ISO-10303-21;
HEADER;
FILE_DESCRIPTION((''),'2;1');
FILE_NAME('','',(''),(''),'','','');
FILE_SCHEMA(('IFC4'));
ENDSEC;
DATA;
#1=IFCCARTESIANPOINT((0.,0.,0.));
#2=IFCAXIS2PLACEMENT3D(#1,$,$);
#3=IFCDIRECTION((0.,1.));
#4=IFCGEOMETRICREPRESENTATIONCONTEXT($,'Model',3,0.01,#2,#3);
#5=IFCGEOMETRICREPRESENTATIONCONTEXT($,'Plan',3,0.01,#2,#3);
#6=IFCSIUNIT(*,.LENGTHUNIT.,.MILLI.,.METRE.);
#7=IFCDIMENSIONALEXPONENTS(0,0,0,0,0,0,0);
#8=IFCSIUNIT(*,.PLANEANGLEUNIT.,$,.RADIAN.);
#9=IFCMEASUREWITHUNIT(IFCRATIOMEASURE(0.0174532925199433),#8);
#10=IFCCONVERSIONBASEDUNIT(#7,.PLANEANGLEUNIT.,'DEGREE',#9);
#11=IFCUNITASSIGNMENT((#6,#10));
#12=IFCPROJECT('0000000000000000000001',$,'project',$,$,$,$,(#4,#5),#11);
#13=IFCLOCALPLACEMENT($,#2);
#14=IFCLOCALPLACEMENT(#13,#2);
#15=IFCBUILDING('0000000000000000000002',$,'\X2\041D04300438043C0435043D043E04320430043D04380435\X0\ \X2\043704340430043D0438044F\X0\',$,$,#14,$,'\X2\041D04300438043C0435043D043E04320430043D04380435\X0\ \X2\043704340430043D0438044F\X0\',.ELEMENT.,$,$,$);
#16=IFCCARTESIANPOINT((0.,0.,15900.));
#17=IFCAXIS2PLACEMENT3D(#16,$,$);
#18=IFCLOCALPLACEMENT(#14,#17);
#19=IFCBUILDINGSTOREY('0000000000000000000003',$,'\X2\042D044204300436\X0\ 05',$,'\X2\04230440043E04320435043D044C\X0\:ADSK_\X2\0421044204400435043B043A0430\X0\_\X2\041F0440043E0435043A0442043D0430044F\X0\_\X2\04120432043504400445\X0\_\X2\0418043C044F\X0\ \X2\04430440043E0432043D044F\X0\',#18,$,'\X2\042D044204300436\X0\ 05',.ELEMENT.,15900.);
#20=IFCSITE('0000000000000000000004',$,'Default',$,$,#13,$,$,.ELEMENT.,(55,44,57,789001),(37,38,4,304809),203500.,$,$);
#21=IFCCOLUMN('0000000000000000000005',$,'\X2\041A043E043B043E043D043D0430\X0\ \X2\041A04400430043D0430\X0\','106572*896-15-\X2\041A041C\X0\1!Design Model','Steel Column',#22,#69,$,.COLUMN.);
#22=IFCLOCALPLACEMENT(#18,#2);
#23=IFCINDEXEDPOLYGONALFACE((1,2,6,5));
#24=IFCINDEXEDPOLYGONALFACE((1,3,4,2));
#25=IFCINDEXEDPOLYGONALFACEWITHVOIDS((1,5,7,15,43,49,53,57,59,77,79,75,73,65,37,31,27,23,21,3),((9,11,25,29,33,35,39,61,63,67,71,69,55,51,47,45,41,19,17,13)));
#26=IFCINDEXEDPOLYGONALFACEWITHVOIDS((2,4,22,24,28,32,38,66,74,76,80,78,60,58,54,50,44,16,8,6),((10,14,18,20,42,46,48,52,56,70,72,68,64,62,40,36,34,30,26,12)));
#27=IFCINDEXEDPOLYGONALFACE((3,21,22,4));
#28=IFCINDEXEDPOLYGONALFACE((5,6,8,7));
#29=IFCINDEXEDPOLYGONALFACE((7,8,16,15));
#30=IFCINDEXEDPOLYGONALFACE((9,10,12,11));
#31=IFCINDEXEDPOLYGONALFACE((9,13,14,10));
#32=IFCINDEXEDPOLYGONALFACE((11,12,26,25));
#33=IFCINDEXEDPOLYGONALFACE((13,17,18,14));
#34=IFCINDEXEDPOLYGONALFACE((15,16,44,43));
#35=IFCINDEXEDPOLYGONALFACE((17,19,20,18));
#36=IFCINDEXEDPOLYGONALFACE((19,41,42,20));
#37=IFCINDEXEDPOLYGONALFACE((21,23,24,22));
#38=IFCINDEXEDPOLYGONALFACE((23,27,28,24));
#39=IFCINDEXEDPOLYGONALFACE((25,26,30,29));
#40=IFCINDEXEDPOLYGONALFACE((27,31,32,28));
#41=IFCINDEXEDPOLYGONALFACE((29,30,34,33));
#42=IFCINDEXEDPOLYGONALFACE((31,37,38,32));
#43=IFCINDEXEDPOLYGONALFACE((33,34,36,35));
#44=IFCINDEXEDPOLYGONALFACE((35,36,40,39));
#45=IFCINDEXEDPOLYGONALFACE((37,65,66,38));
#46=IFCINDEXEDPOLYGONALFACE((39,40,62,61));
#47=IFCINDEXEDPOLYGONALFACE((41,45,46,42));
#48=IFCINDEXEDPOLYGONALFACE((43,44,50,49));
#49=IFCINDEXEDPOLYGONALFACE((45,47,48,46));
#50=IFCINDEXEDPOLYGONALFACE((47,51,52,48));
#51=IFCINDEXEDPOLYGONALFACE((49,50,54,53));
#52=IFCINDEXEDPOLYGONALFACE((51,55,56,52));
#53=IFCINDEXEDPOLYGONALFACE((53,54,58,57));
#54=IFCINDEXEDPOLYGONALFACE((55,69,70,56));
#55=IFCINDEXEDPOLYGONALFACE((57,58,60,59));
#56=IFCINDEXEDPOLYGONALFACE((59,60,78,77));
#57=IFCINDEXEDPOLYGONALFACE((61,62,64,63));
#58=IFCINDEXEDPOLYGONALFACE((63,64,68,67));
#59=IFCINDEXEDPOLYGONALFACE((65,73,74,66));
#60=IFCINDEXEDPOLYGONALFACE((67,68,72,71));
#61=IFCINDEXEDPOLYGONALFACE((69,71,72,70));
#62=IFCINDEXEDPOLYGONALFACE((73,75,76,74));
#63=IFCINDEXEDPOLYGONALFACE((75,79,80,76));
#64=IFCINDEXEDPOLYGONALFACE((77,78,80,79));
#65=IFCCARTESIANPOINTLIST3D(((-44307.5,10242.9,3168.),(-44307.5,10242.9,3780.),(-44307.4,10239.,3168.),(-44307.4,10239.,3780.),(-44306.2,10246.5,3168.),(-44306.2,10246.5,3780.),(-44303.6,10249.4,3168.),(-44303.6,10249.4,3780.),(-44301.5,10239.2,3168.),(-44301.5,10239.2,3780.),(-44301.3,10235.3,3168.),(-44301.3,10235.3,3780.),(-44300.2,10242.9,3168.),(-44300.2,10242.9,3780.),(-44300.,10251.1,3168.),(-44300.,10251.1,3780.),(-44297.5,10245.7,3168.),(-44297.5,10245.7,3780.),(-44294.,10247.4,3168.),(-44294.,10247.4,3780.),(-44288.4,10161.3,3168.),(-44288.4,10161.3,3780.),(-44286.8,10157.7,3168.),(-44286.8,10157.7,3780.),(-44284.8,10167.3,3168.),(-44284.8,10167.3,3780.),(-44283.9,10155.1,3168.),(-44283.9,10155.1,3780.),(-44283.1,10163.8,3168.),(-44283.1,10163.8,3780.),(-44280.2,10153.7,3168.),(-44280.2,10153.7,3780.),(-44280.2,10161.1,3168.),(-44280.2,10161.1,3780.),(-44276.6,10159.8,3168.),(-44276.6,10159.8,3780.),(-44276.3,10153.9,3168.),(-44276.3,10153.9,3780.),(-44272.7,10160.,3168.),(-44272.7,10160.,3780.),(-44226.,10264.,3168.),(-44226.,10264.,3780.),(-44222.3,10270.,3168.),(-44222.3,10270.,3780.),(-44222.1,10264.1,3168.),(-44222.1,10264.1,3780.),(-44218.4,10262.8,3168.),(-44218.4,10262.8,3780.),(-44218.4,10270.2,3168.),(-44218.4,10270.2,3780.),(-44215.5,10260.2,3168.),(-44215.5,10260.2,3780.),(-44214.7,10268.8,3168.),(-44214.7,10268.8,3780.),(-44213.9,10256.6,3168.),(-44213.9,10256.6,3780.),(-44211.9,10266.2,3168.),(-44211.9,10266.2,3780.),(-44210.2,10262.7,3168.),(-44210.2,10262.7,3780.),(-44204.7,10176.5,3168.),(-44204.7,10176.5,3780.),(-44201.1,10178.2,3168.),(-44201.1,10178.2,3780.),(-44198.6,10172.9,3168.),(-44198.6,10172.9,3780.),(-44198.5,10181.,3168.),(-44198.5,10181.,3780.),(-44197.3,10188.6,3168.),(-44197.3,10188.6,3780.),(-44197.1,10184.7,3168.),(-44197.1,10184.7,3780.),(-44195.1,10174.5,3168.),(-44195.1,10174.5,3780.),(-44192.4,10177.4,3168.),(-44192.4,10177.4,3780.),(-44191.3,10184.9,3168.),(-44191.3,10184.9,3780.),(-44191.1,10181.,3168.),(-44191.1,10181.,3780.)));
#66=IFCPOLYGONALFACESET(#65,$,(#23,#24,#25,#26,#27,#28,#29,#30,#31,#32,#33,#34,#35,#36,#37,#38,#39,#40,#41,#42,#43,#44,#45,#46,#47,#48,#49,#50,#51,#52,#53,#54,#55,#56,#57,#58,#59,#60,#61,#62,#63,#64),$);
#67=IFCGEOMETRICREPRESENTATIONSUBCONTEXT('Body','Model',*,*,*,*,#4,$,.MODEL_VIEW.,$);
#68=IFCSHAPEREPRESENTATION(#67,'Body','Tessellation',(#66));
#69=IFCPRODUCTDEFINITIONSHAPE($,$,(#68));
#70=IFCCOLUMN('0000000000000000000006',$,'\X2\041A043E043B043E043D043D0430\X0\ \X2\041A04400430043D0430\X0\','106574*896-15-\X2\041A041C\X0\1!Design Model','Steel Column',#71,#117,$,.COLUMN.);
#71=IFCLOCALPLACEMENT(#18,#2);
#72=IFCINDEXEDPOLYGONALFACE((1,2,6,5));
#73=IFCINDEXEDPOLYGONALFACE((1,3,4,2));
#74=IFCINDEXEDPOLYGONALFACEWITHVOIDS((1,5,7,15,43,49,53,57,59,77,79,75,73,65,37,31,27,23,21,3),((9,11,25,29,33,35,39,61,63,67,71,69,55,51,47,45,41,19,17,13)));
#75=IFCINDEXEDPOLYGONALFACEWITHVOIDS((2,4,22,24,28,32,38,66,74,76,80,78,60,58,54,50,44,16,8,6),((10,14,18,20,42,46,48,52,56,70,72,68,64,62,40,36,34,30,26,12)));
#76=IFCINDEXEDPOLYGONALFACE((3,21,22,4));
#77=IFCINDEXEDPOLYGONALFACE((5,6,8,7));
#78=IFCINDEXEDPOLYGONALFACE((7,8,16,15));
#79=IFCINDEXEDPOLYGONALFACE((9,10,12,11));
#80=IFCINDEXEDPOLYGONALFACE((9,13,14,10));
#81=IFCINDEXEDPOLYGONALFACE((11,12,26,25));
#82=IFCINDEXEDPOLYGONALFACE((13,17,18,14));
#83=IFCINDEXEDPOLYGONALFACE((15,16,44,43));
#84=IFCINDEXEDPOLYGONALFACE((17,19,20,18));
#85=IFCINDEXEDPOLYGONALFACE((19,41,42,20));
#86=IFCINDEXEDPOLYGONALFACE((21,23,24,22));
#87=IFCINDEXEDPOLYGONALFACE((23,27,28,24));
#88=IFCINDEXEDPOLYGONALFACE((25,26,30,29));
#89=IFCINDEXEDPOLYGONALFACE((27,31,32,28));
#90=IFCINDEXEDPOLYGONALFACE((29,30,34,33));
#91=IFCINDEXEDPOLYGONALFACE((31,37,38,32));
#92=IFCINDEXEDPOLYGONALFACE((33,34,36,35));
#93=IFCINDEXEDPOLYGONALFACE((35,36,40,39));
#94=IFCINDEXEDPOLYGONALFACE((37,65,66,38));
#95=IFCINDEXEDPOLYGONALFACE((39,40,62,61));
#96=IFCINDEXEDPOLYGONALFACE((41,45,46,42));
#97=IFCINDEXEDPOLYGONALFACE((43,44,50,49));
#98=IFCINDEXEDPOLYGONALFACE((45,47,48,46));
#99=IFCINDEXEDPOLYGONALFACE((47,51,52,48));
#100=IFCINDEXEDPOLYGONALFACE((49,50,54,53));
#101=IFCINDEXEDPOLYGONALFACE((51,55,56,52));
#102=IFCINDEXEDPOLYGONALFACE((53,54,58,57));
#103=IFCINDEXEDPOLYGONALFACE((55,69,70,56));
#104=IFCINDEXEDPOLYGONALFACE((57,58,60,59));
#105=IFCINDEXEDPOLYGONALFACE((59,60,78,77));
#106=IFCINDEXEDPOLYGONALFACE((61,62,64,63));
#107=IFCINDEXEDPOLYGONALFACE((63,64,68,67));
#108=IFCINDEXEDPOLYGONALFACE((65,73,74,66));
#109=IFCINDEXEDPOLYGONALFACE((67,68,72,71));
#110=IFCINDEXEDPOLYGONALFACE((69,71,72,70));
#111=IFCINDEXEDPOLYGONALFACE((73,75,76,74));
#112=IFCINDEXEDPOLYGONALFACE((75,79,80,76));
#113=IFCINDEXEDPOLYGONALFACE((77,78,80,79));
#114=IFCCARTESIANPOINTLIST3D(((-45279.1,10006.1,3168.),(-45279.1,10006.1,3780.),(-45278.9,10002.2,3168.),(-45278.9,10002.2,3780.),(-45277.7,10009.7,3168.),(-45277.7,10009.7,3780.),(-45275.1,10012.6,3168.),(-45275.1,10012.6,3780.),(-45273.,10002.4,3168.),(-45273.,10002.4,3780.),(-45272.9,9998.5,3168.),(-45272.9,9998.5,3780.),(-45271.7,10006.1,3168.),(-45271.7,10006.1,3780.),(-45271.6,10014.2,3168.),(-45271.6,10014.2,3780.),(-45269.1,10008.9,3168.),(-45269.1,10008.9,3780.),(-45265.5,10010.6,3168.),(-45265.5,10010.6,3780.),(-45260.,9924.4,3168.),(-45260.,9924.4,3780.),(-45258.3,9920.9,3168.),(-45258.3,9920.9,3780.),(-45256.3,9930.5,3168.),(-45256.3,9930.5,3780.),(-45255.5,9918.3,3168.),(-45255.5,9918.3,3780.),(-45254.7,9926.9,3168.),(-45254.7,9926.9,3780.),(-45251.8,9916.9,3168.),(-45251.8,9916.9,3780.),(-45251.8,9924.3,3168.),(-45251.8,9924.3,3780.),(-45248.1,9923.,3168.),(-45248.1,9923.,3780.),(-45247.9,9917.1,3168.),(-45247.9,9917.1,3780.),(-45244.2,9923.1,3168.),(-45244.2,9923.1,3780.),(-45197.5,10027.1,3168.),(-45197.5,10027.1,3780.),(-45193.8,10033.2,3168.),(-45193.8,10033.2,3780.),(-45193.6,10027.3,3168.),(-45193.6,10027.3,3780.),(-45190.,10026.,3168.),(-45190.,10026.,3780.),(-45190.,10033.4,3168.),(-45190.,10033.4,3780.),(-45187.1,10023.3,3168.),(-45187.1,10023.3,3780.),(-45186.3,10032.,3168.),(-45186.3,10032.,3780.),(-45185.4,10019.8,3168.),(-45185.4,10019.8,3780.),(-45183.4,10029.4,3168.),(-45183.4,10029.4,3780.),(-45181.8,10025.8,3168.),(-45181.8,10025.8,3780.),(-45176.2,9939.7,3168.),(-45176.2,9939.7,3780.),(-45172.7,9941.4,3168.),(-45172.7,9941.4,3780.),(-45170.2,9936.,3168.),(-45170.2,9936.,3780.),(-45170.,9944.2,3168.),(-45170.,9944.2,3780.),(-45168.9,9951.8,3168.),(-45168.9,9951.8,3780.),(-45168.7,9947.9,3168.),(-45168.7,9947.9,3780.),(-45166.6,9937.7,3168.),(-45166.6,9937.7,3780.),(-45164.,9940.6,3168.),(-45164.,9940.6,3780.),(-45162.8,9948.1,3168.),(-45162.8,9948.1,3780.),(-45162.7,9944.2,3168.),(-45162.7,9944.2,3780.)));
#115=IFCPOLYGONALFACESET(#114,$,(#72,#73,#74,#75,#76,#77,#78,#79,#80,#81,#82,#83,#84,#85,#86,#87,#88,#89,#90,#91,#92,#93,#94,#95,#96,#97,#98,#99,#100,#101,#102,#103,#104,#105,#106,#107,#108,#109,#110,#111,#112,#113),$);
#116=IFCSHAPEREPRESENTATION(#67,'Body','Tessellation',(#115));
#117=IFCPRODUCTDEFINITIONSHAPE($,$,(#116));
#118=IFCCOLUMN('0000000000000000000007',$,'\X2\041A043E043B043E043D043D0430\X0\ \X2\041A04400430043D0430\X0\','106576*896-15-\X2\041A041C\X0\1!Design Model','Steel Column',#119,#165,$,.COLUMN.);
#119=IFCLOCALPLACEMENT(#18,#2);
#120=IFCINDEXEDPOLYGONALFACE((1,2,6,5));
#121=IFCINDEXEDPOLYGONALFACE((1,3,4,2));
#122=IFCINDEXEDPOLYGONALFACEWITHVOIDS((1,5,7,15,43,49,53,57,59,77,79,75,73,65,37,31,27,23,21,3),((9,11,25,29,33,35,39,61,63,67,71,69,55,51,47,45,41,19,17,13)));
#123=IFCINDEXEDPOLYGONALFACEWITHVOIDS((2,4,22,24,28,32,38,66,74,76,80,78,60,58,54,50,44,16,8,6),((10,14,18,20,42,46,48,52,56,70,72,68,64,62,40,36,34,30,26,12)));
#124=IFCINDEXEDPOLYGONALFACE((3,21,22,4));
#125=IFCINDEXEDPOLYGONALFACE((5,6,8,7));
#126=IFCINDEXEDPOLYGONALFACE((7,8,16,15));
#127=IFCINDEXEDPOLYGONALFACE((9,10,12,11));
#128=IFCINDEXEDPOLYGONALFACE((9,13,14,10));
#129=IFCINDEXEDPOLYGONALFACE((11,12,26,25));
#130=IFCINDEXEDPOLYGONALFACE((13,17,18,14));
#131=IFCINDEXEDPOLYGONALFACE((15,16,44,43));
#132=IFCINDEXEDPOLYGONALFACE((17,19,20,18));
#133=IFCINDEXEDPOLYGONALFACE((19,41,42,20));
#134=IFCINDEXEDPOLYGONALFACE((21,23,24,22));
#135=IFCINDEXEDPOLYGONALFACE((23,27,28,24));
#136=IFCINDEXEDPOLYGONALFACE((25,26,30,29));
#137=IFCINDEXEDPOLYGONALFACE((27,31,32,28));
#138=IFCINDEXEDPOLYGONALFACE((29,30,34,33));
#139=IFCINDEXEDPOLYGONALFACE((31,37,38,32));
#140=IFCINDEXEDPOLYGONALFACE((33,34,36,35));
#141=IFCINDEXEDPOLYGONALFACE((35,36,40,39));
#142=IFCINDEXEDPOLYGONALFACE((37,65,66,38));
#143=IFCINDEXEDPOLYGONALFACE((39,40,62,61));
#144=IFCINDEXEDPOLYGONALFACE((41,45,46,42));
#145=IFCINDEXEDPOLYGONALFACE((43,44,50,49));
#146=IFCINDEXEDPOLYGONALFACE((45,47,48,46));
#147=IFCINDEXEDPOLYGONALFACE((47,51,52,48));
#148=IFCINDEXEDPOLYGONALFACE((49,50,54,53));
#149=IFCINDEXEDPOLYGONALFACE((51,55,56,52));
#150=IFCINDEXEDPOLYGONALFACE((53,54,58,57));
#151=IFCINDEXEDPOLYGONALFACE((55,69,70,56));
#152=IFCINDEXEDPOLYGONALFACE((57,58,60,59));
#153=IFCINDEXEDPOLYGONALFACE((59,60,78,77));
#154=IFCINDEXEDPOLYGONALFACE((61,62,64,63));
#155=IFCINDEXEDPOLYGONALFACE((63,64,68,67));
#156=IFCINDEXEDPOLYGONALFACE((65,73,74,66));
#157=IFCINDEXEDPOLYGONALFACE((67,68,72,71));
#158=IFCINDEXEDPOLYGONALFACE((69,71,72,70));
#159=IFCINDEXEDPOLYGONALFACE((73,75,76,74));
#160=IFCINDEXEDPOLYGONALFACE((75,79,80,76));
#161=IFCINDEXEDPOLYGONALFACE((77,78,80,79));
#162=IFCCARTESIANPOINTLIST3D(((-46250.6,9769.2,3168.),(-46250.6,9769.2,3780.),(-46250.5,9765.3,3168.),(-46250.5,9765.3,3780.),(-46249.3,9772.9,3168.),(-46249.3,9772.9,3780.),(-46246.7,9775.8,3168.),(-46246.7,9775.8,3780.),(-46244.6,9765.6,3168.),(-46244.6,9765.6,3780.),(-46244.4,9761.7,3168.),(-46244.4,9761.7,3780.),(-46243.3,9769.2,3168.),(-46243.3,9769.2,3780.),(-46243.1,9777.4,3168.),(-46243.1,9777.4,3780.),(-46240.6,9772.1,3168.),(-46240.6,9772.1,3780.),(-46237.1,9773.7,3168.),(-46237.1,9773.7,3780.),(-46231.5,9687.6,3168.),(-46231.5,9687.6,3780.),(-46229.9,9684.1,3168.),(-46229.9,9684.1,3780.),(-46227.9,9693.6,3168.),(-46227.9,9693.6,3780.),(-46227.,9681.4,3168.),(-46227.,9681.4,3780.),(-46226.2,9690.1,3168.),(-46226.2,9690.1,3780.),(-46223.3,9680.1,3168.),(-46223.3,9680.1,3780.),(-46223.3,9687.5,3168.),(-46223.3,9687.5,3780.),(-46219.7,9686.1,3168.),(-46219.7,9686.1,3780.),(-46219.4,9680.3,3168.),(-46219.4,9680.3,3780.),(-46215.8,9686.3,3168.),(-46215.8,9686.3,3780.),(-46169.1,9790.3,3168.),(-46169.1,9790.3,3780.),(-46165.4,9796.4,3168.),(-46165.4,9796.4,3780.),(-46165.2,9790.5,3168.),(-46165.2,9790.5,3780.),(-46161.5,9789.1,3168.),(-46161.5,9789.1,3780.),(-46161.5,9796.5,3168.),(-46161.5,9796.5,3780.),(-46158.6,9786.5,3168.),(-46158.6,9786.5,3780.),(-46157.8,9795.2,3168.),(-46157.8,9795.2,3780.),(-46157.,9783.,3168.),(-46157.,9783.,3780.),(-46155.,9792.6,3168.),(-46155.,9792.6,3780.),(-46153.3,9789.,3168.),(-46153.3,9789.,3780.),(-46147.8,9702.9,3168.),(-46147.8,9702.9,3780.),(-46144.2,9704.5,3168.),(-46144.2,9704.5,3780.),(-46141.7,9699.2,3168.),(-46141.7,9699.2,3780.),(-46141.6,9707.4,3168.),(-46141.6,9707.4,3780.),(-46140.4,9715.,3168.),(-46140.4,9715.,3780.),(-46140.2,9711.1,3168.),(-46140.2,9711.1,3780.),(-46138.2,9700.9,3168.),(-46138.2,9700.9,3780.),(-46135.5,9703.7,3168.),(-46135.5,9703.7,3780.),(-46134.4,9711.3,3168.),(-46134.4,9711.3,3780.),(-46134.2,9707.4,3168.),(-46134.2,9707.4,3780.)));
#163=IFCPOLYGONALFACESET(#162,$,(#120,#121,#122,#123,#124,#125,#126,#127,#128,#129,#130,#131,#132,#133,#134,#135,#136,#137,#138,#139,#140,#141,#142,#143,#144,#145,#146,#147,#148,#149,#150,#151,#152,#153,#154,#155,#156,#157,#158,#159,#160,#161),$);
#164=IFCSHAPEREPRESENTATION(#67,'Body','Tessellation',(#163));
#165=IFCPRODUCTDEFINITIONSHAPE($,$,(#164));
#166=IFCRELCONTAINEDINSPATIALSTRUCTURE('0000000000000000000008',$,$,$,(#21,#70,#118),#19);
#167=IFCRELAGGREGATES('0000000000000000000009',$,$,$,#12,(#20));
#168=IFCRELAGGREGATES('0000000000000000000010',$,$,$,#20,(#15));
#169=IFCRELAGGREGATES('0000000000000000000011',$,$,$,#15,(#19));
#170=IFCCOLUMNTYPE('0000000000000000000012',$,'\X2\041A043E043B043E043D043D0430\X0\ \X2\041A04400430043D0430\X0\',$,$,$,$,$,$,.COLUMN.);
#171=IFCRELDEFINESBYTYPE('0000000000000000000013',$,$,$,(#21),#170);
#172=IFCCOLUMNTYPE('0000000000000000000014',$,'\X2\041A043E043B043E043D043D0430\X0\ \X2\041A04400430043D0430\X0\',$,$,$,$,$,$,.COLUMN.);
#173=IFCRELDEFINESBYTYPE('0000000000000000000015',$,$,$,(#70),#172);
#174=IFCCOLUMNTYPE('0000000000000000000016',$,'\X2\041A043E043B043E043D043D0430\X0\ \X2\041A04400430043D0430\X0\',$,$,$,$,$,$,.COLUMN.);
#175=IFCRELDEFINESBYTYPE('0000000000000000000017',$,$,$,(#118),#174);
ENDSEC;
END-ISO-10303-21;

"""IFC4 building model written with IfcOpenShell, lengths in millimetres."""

from ifc_helpers import new_model, entity, si_unit, converted_unit, direction, frame, origin, place, context, subcontext, project, spatial, indexed_curve, outline, extrude, type_object, element, save


model = new_model("IFC4")

# Units and contexts
model_context = context("Model", 3, precision=0.01, world=origin(), true_north=direction((0.0, 1.0)))
plan_context = context("Plan", 3, precision=0.01, world=origin(), true_north=direction((0.0, 1.0)))
body_context = subcontext(model_context, "Body", "Model", "MODEL_VIEW")
ifc_project = project(units=[si_unit("LENGTHUNIT", "METRE", prefix="MILLI"), converted_unit("PLANEANGLEUNIT", "DEGREE", entity("IfcRatioMeasure", 0.0174532925199433), si_unit("PLANEANGLEUNIT", "RADIAN"), dimensions=[0, 0, 0, 0, 0, 0, 0])], contexts=[model_context, plan_context])

# Site, building, storey
site_placement = place(None, origin())
site = spatial("IfcSite", under=ifc_project, at=site_placement, Name="Default", CompositionType="ELEMENT", RefLatitude=(55, 44, 57, 789001), RefLongitude=(37, 38, 4, 304809), RefElevation=203500.0)
building_placement = place(site_placement, origin())
building = spatial("IfcBuilding", under=site, at=building_placement, Name="Наименование здания", LongName="Наименование здания", CompositionType="ELEMENT")
storey_placement = place(building_placement, frame((0.0, 0.0, 15900.0)))
storey = spatial("IfcBuildingStorey", under=building, at=storey_placement, Name="Этаж 05", ObjectType="Уровень:ADSK_Стрелка_Проектная_Вверх_Имя уровня", LongName="Этаж 05", CompositionType="ELEMENT", Elevation=15900.0)

# Columns
placement = place(storey_placement, origin())
column_type_1 = type_object("IfcColumnType", Name="Колонна Крана", PredefinedType="COLUMN")
element("IfcColumn", 1, at=placement, inside=storey, type_object=column_type_1, Name="Колонна Крана", Description="106572*896-15-КМ1!Design Model", ObjectType="Steel Column", PredefinedType="COLUMN", context=body_context, shape_type="SweptSolid", body=[
    extrude(outline(indexed_curve([(29.5, -56.8), (33.4, -56.8), (37.0, -55.3), (39.7, -52.6), (41.2, -49.0), (56.8, 29.5), (56.8, 33.4), (55.3, 37.0), (52.6, 39.7), (49.0, 41.2), (-29.5, 56.8), (-33.4, 56.8), (-37.0, 55.3), (-39.7, 52.6), (-41.2, 49.0), (-56.8, -29.5), (-56.8, -33.4), (-55.3, -37.0), (-52.6, -39.7), (-49.0, -41.2), (29.5, -56.8)], self_intersect=False), holes=[indexed_curve([(-43.1, -37.3), (-46.7, -35.8), (-49.5, -33.1), (-51.0, -29.5), (-51.0, -25.5), (-37.3, 43.1), (-35.8, 46.7), (-33.1, 49.5), (-29.5, 51.0), (-25.5, 51.0), (43.1, 37.3), (46.7, 35.8), (49.5, 33.1), (51.0, 29.5), (51.0, 25.5), (37.3, -43.1), (35.8, -46.7), (33.1, -49.5), (29.5, -51.0), (25.5, -51.0), (-43.1, -37.3)], self_intersect=False)]), frame((-44249.3, 10212.0, 3168.0), z_axis=(0.0, 0.0, 1.0), x_axis=(0.906681, 0.421816, 0.0)), (0.0, 0.0, 1.0), 612.0),
])
column_type_2 = type_object("IfcColumnType", Name="Колонна Крана", PredefinedType="COLUMN")
element("IfcColumn", 2, at=placement, inside=storey, type_object=column_type_2, Name="Колонна Крана", Description="106574*896-15-КМ1!Design Model", ObjectType="Steel Column", PredefinedType="COLUMN", context=body_context, shape_type="SweptSolid", body=[
    extrude(outline(indexed_curve([(29.5, -56.8), (33.4, -56.8), (37.0, -55.3), (39.7, -52.6), (41.2, -49.0), (56.8, 29.5), (56.8, 33.4), (55.3, 37.0), (52.6, 39.7), (49.0, 41.2), (-29.5, 56.8), (-33.4, 56.8), (-37.0, 55.3), (-39.7, 52.6), (-41.2, 49.0), (-56.8, -29.5), (-56.8, -33.4), (-55.3, -37.0), (-52.6, -39.7), (-49.0, -41.2), (29.5, -56.8)], self_intersect=False), holes=[indexed_curve([(-43.1, -37.3), (-46.7, -35.8), (-49.5, -33.1), (-51.0, -29.5), (-51.0, -25.5), (-37.3, 43.1), (-35.8, 46.7), (-33.1, 49.5), (-29.5, 51.0), (-25.5, 51.0), (43.1, 37.3), (46.7, 35.8), (49.5, 33.1), (51.0, 29.5), (51.0, 25.5), (37.3, -43.1), (35.8, -46.7), (33.1, -49.5), (29.5, -51.0), (25.5, -51.0), (-43.1, -37.3)], self_intersect=False)]), frame((-45220.9, 9975.1, 3168.0), z_axis=(0.0, 0.0, 1.0), x_axis=(0.906681, 0.421816, 0.0)), (0.0, 0.0, 1.0), 612.0),
])
column_type_3 = type_object("IfcColumnType", Name="Колонна Крана", PredefinedType="COLUMN")
element("IfcColumn", 3, at=placement, inside=storey, type_object=column_type_3, Name="Колонна Крана", Description="106576*896-15-КМ1!Design Model", ObjectType="Steel Column", PredefinedType="COLUMN", context=body_context, shape_type="SweptSolid", body=[
    extrude(outline(indexed_curve([(29.5, -56.8), (33.4, -56.8), (37.0, -55.3), (39.7, -52.6), (41.2, -49.0), (56.8, 29.5), (56.8, 33.4), (55.3, 37.0), (52.6, 39.7), (49.0, 41.2), (-29.5, 56.8), (-33.4, 56.8), (-37.0, 55.3), (-39.7, 52.6), (-41.2, 49.0), (-56.8, -29.5), (-56.8, -33.4), (-55.3, -37.0), (-52.6, -39.7), (-49.0, -41.2), (29.5, -56.8)], self_intersect=False), holes=[indexed_curve([(-43.1, -37.3), (-46.7, -35.8), (-49.5, -33.1), (-51.0, -29.5), (-51.0, -25.5), (-37.3, 43.1), (-35.8, 46.7), (-33.1, 49.5), (-29.5, 51.0), (-25.5, 51.0), (43.1, 37.3), (46.7, 35.8), (49.5, 33.1), (51.0, 29.5), (51.0, 25.5), (37.3, -43.1), (35.8, -46.7), (33.1, -49.5), (29.5, -51.0), (25.5, -51.0), (-43.1, -37.3)], self_intersect=False)]), frame((-46192.4, 9738.3, 3168.0), z_axis=(0.0, 0.0, 1.0), x_axis=(0.906681, 0.421816, 0.0)), (0.0, 0.0, 1.0), 612.0),
])

save(model, "model.ifc")
